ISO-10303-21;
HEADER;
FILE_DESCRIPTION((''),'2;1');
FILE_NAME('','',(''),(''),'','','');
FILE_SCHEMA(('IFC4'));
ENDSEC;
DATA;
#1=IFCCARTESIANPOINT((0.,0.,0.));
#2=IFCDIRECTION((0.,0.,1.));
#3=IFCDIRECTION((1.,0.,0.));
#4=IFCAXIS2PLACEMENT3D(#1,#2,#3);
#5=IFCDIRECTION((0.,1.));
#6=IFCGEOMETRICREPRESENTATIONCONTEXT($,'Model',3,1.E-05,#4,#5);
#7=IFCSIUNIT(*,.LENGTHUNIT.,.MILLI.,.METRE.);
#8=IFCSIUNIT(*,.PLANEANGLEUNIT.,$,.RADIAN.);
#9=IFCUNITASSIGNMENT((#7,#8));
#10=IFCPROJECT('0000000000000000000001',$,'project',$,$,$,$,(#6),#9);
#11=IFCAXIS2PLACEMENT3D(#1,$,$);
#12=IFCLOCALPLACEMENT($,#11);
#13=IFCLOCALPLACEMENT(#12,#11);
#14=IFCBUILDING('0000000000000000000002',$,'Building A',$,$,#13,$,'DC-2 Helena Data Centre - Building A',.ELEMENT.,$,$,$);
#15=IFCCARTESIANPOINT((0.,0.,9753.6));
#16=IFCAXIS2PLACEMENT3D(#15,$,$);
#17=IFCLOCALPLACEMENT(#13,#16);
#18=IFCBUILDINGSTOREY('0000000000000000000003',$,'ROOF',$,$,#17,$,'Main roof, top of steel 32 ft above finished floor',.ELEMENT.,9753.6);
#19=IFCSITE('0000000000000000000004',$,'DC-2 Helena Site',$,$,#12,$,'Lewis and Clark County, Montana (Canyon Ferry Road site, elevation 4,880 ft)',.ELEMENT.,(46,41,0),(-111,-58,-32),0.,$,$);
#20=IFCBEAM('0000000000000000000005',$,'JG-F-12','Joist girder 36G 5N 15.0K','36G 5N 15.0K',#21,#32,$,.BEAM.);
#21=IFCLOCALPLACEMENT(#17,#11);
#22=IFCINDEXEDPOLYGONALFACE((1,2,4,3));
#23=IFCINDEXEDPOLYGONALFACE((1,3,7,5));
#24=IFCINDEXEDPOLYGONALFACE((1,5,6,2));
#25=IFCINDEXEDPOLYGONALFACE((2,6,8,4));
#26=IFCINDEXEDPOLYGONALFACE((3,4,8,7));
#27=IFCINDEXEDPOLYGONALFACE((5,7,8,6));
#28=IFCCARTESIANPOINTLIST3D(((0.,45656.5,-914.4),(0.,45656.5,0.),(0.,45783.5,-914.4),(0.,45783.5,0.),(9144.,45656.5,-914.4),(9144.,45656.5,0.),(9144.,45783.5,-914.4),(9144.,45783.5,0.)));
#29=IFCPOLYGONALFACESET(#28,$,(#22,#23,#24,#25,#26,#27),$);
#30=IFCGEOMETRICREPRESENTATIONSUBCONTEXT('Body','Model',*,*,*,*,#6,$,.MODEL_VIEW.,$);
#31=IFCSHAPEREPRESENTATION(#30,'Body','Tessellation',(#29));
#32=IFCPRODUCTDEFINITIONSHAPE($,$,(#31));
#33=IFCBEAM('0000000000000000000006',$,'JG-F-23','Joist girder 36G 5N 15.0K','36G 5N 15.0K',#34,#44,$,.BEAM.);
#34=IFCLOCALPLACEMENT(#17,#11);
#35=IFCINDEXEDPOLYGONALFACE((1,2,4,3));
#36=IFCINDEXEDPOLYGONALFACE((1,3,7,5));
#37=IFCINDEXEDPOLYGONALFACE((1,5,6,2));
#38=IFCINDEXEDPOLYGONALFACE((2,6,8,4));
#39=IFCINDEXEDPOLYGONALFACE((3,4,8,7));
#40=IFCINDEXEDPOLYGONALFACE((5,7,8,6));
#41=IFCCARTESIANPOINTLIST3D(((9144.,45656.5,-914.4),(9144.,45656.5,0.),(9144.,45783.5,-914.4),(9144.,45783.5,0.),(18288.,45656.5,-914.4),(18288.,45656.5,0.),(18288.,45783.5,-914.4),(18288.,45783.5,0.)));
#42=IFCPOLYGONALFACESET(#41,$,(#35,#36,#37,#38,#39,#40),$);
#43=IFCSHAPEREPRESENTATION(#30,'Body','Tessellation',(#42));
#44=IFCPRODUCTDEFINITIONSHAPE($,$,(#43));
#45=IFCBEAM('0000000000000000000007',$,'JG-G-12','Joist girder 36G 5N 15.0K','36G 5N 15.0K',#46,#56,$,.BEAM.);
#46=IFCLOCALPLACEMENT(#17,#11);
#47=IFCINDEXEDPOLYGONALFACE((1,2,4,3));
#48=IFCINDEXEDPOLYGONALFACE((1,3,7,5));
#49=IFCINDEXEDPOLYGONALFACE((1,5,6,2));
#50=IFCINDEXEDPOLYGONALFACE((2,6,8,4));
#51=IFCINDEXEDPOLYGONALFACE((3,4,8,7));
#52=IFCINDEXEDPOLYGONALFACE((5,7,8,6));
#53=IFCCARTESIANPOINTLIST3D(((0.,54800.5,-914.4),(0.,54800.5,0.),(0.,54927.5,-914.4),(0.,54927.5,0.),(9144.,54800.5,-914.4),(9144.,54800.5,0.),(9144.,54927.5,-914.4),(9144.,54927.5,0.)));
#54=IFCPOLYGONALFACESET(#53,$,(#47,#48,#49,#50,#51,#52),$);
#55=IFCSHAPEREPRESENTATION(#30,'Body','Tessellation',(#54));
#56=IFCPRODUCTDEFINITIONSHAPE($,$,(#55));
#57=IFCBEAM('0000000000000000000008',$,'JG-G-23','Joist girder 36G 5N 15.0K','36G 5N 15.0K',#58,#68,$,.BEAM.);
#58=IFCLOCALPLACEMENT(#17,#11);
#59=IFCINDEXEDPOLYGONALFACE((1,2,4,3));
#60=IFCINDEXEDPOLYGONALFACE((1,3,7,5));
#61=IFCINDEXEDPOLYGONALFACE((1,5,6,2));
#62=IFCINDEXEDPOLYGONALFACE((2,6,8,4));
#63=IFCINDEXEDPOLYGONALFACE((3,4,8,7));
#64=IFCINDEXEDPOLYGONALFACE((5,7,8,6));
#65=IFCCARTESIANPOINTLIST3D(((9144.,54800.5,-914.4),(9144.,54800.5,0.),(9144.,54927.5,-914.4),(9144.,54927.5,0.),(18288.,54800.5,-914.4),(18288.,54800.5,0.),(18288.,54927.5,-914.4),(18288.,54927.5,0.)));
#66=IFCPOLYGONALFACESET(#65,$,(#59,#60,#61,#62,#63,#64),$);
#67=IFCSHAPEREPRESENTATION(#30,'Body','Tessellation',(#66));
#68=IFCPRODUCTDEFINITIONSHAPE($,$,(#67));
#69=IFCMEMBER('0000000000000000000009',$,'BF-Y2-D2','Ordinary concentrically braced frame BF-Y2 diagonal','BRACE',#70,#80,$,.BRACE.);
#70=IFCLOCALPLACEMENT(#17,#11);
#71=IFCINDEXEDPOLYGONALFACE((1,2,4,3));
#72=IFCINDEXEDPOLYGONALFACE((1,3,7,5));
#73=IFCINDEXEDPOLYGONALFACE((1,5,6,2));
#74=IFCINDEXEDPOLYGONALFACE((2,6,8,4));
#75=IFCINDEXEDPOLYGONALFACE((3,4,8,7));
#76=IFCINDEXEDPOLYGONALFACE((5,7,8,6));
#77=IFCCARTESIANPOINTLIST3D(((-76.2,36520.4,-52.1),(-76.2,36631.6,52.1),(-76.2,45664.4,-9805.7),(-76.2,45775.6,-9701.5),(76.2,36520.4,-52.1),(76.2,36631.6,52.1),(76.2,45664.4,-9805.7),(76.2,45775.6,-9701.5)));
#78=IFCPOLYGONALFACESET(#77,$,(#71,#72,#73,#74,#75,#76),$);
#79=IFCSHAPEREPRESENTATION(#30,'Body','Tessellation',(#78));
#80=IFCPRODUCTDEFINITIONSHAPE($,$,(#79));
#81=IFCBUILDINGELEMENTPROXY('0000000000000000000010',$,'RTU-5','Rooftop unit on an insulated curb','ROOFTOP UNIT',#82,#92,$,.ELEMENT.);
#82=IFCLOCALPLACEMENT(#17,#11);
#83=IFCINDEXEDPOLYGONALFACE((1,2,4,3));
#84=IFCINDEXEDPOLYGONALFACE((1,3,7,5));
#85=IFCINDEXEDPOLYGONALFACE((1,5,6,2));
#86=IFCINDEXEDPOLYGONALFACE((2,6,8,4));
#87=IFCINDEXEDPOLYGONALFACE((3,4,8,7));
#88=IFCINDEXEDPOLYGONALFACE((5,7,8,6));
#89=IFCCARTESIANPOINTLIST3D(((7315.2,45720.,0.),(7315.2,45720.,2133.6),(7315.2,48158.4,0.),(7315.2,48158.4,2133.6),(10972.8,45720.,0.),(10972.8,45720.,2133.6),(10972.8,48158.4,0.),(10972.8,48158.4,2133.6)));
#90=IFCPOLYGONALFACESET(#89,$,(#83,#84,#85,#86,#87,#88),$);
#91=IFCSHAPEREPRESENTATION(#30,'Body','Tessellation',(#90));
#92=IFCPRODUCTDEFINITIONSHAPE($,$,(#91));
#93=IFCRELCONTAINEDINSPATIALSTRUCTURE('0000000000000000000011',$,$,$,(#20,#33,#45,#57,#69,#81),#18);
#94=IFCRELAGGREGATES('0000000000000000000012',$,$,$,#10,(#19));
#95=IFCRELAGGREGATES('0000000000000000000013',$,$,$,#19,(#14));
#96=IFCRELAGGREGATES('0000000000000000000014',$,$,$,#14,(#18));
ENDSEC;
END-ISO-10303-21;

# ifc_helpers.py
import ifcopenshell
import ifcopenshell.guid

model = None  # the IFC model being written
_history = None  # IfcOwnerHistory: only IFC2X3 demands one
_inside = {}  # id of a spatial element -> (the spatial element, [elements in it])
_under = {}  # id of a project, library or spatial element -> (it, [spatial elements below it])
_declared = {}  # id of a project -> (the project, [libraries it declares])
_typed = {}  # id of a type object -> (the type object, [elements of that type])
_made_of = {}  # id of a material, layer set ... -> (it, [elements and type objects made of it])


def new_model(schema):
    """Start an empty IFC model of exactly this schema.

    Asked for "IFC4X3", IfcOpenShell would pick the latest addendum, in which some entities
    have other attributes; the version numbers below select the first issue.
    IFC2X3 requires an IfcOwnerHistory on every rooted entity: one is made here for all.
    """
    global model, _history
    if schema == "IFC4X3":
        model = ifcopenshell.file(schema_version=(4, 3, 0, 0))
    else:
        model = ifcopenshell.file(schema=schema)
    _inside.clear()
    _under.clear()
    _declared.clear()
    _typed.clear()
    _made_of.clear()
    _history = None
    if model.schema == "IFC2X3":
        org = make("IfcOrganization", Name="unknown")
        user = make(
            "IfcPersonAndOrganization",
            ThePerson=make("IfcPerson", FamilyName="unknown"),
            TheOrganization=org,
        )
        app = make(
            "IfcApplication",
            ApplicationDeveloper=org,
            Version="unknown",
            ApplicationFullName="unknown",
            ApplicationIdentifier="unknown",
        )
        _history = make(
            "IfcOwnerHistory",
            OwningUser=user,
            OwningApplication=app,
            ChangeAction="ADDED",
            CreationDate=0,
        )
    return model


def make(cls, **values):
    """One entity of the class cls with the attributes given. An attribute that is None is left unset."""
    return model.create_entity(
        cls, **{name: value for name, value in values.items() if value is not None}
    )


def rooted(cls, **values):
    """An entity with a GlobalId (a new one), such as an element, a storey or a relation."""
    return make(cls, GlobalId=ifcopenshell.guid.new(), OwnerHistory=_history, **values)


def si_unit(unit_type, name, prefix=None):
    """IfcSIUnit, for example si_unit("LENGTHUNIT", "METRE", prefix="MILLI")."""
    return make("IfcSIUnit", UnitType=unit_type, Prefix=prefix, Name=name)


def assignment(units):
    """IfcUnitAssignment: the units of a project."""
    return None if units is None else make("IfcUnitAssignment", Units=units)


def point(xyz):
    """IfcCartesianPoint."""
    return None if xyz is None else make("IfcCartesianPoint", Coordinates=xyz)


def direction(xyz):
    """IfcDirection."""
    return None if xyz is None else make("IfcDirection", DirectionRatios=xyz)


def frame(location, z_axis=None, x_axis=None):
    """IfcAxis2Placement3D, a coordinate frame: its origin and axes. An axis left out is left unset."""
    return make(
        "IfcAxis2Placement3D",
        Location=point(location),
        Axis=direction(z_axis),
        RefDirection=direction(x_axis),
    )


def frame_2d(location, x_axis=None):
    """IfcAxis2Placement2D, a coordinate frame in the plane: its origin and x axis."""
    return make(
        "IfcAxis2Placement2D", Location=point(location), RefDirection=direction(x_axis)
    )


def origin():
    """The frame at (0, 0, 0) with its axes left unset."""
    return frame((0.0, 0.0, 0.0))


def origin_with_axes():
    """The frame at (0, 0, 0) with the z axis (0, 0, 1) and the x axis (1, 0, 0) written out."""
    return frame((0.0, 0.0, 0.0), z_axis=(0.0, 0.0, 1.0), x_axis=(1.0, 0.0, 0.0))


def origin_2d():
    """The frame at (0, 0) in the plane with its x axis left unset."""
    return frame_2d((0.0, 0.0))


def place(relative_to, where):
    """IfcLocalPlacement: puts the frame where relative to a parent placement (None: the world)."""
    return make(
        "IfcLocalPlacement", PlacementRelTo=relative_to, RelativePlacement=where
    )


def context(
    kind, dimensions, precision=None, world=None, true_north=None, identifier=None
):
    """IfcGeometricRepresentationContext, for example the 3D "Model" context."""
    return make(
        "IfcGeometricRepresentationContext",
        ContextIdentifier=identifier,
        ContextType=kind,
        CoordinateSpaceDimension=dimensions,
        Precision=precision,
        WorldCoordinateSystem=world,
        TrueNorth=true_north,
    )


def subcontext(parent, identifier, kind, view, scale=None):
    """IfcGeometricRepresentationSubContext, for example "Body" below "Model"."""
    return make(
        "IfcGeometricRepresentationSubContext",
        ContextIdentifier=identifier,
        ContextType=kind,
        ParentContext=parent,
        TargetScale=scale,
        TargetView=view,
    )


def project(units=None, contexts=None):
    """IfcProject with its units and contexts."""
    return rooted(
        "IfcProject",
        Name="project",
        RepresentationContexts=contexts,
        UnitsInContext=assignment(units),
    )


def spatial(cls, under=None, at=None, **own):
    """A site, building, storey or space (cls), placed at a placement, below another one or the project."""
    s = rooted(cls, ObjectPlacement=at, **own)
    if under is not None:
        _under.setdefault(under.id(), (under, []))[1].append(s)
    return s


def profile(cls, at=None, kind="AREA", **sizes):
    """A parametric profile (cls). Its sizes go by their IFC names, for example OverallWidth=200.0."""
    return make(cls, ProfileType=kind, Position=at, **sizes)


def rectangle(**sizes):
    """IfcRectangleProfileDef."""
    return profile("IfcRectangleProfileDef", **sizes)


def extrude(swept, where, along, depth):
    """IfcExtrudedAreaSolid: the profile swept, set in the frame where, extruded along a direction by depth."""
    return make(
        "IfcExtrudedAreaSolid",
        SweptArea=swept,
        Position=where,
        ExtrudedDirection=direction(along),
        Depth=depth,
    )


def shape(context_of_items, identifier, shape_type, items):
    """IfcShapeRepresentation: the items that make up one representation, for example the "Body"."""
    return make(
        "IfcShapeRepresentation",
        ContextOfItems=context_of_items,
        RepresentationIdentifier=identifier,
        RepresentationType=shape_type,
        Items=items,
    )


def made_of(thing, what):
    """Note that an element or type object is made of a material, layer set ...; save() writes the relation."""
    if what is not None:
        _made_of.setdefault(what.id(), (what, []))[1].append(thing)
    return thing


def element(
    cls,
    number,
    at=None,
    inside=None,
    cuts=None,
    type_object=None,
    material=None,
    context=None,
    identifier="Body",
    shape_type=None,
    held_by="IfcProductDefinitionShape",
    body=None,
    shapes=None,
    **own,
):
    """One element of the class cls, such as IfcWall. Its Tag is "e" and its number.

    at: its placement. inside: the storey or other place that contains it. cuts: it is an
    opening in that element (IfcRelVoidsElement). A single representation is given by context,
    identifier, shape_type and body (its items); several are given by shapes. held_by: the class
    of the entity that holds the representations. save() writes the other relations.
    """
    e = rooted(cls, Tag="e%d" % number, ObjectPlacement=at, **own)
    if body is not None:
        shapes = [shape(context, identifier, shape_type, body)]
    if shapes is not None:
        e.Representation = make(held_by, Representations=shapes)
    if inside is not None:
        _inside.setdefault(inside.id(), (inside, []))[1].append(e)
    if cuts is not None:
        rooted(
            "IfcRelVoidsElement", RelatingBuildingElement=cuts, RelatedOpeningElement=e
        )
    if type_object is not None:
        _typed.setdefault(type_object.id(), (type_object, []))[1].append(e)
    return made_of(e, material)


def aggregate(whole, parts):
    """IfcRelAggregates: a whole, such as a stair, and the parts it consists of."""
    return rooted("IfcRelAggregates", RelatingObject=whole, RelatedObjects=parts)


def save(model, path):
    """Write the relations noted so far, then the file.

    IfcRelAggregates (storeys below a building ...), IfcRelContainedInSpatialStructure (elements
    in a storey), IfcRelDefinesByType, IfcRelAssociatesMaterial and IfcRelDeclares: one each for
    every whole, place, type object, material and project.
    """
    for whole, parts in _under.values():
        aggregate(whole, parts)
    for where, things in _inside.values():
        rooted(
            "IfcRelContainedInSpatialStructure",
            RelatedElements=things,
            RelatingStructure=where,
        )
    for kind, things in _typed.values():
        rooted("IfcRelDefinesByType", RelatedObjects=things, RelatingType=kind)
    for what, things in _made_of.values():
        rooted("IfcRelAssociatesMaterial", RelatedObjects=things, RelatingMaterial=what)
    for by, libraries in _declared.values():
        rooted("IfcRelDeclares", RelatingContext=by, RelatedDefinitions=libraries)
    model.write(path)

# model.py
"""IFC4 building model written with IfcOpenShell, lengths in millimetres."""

from ifc_helpers import new_model, si_unit, direction, frame, origin, origin_with_axes, origin_2d, place, context, subcontext, project, spatial, rectangle, extrude, element, save


model = new_model("IFC4")

# Units and contexts
model_context = context("Model", 3, precision=1e-05, world=origin_with_axes(), true_north=direction((0.0, 1.0)))
body_context = subcontext(model_context, "Body", "Model", "MODEL_VIEW")
ifc_project = project(units=[si_unit("LENGTHUNIT", "METRE", prefix="MILLI"), si_unit("PLANEANGLEUNIT", "RADIAN")], contexts=[model_context])

# Site, building, storey
site_placement = place(None, origin())
site = spatial("IfcSite", under=ifc_project, at=site_placement, Name="DC-2 Helena Site", LongName="Lewis and Clark County, Montana (Canyon Ferry Road site, elevation 4,880 ft)", CompositionType="ELEMENT", RefLatitude=(46, 41, 0), RefLongitude=(-111, -58, -32), RefElevation=0.0)
building_placement = place(site_placement, origin())
building = spatial("IfcBuilding", under=site, at=building_placement, Name="Building A", LongName="DC-2 Helena Data Centre - Building A", CompositionType="ELEMENT")
storey_placement = place(building_placement, frame((0.0, 0.0, 9753.6)))
storey = spatial("IfcBuildingStorey", under=building, at=storey_placement, Name="ROOF", LongName="Main roof, top of steel 32 ft above finished floor", CompositionType="ELEMENT", Elevation=9753.6)

# Shared definitions
placement_1 = place(storey_placement, frame((0.0, 45720.0, -9753.6)))

# Beams
placement_2 = place(storey_placement, frame((0.0, 45720.0, 0.0)))
placement_3 = place(storey_placement, frame((9144.0, 45720.0, 0.0)))
element("IfcBeam", 1, at=placement_2, inside=storey, Name="JG-F-12", Description="Joist girder 36G 5N 15.0K", ObjectType="36G 5N 15.0K", PredefinedType="BEAM", context=body_context, shape_type="SweptSolid", body=[
    extrude(rectangle(XDim=127.0, YDim=914.4, at=origin_2d()), frame((0.0, 0.0, -457.2), z_axis=(1.0, 0.0, 0.0), x_axis=(0.0, 1.0, 0.0)), (0.0, 0.0, 1.0), 9144.0),
])
element("IfcBeam", 2, at=placement_3, inside=storey, Name="JG-F-23", Description="Joist girder 36G 5N 15.0K", ObjectType="36G 5N 15.0K", PredefinedType="BEAM", context=body_context, shape_type="SweptSolid", body=[
    extrude(rectangle(XDim=127.0, YDim=914.4, at=origin_2d()), frame((0.0, 0.0, -457.2), z_axis=(1.0, 0.0, 0.0), x_axis=(0.0, 1.0, 0.0)), (0.0, 0.0, 1.0), 9144.0),
])
for number, where, name in (
    (3, (0.0, 54864.0, 0.0), "JG-G-12"),
    (4, (9144.0, 54864.0, 0.0), "JG-G-23"),
):
    element("IfcBeam", number, at=place(storey_placement, frame(where)), inside=storey, Name=name, Description="Joist girder 36G 5N 15.0K", ObjectType="36G 5N 15.0K", PredefinedType="BEAM", context=body_context, shape_type="SweptSolid", body=[
        extrude(rectangle(XDim=127.0, YDim=914.4, at=origin_2d()), frame((0.0, 0.0, -457.2), z_axis=(1.0, 0.0, 0.0), x_axis=(0.0, 1.0, 0.0)), (0.0, 0.0, 1.0), 9144.0),
    ])

# Member
element("IfcMember", 5, at=placement_1, inside=storey, Name="BF-Y2-D2", Description="Ordinary concentrically braced frame BF-Y2 diagonal", ObjectType="BRACE", PredefinedType="BRACE", context=body_context, shape_type="SweptSolid", body=[
    extrude(rectangle(XDim=152.4, YDim=152.4, at=origin_2d()), frame((0.0, 0.0, 0.0), z_axis=(0.0, -0.683941, 0.729537), x_axis=(1.0, 0.0, 0.0)), (0.0, 0.0, 1.0), 13369.6),
])

# Building element proxy
proxy_placement = place(storey_placement, frame((9144.0, 46939.2, 0.0)))
element("IfcBuildingElementProxy", 6, at=proxy_placement, inside=storey, Name="RTU-5", Description="Rooftop unit on an insulated curb", ObjectType="ROOFTOP UNIT", PredefinedType="ELEMENT", context=body_context, shape_type="SweptSolid", body=[
    extrude(rectangle(XDim=3657.6, YDim=2438.4, at=origin_2d()), origin(), (0.0, 0.0, 1.0), 2133.6),
])

save(model, "model.ifc")
